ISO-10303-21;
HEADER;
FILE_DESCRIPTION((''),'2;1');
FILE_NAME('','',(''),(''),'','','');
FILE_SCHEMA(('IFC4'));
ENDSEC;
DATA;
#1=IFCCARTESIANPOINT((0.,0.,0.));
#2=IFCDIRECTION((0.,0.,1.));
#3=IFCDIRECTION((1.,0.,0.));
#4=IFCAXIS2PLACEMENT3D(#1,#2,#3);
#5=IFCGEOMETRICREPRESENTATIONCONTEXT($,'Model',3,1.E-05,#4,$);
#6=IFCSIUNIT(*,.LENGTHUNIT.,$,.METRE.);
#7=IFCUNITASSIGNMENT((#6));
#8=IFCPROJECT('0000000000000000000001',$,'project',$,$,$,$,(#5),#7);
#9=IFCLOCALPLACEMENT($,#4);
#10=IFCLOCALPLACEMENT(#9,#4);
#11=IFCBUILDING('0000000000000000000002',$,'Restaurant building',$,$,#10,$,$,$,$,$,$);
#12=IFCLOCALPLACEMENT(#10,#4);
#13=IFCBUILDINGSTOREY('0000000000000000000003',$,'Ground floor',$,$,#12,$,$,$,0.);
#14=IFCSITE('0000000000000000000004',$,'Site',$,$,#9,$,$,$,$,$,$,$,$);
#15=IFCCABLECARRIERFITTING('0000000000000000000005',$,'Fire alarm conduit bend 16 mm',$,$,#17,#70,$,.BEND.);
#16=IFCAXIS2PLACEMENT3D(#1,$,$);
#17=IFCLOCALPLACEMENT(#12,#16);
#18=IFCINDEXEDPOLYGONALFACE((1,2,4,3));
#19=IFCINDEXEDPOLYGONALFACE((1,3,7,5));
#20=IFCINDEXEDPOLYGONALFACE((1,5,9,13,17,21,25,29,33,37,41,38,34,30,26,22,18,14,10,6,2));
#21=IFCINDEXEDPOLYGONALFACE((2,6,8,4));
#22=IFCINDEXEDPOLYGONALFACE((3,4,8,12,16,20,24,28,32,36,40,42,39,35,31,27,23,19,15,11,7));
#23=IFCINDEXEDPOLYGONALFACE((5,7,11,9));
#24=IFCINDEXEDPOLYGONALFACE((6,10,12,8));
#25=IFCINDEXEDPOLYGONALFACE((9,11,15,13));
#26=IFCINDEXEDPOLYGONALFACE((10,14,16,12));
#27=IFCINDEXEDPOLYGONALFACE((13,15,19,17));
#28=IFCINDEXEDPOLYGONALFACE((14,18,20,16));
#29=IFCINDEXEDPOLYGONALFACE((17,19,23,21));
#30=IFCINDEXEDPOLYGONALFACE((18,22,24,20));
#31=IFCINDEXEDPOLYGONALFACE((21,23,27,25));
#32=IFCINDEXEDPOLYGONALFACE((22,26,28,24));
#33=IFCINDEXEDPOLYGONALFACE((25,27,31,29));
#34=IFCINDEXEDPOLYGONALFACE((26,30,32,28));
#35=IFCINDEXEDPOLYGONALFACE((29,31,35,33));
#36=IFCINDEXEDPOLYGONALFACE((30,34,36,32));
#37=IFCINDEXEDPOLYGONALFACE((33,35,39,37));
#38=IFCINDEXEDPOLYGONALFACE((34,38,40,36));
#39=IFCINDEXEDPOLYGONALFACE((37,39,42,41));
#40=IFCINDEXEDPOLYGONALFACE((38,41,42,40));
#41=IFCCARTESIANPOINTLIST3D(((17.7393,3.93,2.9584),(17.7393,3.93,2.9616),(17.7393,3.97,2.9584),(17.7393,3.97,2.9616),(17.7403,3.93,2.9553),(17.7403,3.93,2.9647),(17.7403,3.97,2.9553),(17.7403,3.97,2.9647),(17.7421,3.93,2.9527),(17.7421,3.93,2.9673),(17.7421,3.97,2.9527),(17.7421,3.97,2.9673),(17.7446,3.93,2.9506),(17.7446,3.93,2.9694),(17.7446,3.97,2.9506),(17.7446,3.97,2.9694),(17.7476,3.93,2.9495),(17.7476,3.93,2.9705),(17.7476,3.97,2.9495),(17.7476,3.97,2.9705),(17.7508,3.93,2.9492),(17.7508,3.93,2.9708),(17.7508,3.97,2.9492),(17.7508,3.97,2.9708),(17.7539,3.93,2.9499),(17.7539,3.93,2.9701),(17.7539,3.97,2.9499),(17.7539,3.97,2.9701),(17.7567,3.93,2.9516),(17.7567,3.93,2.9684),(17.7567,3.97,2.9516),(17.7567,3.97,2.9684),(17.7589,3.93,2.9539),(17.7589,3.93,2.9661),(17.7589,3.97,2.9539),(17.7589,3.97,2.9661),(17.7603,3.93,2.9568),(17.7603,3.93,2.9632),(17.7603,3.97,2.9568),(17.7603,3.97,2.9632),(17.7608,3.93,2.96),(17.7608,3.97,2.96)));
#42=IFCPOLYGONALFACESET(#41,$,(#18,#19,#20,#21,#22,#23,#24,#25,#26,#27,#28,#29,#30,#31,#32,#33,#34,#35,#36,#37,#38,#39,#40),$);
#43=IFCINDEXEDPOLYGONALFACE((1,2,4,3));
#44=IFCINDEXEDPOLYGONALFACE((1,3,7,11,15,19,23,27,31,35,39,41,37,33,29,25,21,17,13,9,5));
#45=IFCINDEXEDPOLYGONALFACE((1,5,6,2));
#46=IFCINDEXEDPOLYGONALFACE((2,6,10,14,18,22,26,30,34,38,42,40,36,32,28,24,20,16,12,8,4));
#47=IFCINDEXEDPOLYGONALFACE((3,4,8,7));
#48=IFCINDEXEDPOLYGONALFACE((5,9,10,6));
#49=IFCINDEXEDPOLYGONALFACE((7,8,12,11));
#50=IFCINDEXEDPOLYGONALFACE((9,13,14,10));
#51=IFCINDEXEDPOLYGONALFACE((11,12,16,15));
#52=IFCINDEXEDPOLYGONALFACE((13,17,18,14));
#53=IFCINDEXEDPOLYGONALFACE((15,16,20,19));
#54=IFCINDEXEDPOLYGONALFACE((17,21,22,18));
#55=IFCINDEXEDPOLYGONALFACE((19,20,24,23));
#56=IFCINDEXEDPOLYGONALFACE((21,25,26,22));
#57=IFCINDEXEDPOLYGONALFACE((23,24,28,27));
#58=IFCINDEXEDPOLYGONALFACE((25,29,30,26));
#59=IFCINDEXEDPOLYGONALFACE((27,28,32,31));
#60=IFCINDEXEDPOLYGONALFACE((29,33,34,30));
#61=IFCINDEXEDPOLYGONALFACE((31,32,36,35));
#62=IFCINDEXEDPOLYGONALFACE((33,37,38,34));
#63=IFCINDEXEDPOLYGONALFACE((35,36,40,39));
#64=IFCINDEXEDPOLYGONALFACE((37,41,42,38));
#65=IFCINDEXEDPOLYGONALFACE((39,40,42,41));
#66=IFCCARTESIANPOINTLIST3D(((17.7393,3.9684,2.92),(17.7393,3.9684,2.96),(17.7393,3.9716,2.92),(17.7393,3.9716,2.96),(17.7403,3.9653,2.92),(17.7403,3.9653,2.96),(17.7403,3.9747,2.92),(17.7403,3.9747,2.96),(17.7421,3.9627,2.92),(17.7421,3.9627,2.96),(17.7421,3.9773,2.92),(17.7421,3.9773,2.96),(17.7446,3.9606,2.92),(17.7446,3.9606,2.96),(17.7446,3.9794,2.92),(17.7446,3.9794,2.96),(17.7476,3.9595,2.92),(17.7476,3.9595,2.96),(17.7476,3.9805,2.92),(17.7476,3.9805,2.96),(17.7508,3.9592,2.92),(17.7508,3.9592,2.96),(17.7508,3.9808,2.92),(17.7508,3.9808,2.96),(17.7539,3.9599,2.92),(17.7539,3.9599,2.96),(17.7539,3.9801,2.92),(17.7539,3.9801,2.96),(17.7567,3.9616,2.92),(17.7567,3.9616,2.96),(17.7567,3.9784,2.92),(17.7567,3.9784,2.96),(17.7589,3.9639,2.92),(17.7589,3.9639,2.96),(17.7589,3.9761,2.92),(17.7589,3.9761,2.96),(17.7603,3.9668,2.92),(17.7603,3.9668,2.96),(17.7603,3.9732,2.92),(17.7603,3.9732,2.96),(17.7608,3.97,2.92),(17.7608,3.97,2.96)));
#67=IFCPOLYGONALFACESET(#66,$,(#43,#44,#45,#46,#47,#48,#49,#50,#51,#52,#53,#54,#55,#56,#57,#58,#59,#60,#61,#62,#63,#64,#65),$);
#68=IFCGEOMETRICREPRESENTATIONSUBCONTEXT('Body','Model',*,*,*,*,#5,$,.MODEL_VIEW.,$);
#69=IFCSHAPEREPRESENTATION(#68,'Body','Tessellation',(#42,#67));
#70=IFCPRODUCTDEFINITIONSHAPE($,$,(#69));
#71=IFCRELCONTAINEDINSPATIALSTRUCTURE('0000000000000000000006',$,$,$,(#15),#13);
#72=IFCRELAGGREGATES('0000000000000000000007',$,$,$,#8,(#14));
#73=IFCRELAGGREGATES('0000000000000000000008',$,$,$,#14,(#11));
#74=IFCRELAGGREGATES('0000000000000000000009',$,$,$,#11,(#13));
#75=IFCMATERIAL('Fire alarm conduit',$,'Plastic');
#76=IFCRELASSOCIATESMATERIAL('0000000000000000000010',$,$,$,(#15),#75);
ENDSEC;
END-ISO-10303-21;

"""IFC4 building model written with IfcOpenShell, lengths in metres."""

from ifc_helpers import new_model, si_unit, frame, origin_with_axes, origin_2d, place, context, subcontext, project, spatial, circle, extrude, material, element, save


model = new_model("IFC4")

# Units and contexts
model_context = context("Model", 3, precision=1e-05, world=origin_with_axes())
body_context = subcontext(model_context, "Body", "Model", "MODEL_VIEW")
ifc_project = project(units=[si_unit("LENGTHUNIT", "METRE")], contexts=[model_context])

# Site, building, storey
site_placement = place(None, origin_with_axes())
site = spatial("IfcSite", under=ifc_project, at=site_placement, Name="Site")
building_placement = place(site_placement, origin_with_axes())
building = spatial("IfcBuilding", under=site, at=building_placement, Name="Restaurant building")
storey_placement = place(building_placement, origin_with_axes())
storey = spatial("IfcBuildingStorey", under=building, at=storey_placement, Name="Ground floor", Elevation=0.0)

# Shared definitions
ifc_material_1 = material(Name="Fire alarm conduit", Category="Plastic")

# Cable carrier fitting
cable_carrier_fitting_1_placement = place(storey_placement, frame((17.75, 3.97, 2.96)))
element("IfcCableCarrierFitting", 1, at=cable_carrier_fitting_1_placement, inside=storey, material=ifc_material_1, Name="Fire alarm conduit bend 16 mm", PredefinedType="BEND", context=body_context, shape_type="SweptSolid", body=[
    extrude(circle(Radius=0.0108, at=origin_2d()), frame((0.0, 0.0, 0.0), z_axis=(0.0, -1.0, 0.0), x_axis=(1.0, 0.0, 0.0)), (0.0, 0.0, 1.0), 0.04),
    extrude(circle(Radius=0.0108, at=origin_2d()), frame((0.0, 0.0, 0.0), z_axis=(0.0, 0.0, -1.0), x_axis=(1.0, 0.0, 0.0)), (0.0, 0.0, 1.0), 0.04),
])

save(model, "model.ifc")
